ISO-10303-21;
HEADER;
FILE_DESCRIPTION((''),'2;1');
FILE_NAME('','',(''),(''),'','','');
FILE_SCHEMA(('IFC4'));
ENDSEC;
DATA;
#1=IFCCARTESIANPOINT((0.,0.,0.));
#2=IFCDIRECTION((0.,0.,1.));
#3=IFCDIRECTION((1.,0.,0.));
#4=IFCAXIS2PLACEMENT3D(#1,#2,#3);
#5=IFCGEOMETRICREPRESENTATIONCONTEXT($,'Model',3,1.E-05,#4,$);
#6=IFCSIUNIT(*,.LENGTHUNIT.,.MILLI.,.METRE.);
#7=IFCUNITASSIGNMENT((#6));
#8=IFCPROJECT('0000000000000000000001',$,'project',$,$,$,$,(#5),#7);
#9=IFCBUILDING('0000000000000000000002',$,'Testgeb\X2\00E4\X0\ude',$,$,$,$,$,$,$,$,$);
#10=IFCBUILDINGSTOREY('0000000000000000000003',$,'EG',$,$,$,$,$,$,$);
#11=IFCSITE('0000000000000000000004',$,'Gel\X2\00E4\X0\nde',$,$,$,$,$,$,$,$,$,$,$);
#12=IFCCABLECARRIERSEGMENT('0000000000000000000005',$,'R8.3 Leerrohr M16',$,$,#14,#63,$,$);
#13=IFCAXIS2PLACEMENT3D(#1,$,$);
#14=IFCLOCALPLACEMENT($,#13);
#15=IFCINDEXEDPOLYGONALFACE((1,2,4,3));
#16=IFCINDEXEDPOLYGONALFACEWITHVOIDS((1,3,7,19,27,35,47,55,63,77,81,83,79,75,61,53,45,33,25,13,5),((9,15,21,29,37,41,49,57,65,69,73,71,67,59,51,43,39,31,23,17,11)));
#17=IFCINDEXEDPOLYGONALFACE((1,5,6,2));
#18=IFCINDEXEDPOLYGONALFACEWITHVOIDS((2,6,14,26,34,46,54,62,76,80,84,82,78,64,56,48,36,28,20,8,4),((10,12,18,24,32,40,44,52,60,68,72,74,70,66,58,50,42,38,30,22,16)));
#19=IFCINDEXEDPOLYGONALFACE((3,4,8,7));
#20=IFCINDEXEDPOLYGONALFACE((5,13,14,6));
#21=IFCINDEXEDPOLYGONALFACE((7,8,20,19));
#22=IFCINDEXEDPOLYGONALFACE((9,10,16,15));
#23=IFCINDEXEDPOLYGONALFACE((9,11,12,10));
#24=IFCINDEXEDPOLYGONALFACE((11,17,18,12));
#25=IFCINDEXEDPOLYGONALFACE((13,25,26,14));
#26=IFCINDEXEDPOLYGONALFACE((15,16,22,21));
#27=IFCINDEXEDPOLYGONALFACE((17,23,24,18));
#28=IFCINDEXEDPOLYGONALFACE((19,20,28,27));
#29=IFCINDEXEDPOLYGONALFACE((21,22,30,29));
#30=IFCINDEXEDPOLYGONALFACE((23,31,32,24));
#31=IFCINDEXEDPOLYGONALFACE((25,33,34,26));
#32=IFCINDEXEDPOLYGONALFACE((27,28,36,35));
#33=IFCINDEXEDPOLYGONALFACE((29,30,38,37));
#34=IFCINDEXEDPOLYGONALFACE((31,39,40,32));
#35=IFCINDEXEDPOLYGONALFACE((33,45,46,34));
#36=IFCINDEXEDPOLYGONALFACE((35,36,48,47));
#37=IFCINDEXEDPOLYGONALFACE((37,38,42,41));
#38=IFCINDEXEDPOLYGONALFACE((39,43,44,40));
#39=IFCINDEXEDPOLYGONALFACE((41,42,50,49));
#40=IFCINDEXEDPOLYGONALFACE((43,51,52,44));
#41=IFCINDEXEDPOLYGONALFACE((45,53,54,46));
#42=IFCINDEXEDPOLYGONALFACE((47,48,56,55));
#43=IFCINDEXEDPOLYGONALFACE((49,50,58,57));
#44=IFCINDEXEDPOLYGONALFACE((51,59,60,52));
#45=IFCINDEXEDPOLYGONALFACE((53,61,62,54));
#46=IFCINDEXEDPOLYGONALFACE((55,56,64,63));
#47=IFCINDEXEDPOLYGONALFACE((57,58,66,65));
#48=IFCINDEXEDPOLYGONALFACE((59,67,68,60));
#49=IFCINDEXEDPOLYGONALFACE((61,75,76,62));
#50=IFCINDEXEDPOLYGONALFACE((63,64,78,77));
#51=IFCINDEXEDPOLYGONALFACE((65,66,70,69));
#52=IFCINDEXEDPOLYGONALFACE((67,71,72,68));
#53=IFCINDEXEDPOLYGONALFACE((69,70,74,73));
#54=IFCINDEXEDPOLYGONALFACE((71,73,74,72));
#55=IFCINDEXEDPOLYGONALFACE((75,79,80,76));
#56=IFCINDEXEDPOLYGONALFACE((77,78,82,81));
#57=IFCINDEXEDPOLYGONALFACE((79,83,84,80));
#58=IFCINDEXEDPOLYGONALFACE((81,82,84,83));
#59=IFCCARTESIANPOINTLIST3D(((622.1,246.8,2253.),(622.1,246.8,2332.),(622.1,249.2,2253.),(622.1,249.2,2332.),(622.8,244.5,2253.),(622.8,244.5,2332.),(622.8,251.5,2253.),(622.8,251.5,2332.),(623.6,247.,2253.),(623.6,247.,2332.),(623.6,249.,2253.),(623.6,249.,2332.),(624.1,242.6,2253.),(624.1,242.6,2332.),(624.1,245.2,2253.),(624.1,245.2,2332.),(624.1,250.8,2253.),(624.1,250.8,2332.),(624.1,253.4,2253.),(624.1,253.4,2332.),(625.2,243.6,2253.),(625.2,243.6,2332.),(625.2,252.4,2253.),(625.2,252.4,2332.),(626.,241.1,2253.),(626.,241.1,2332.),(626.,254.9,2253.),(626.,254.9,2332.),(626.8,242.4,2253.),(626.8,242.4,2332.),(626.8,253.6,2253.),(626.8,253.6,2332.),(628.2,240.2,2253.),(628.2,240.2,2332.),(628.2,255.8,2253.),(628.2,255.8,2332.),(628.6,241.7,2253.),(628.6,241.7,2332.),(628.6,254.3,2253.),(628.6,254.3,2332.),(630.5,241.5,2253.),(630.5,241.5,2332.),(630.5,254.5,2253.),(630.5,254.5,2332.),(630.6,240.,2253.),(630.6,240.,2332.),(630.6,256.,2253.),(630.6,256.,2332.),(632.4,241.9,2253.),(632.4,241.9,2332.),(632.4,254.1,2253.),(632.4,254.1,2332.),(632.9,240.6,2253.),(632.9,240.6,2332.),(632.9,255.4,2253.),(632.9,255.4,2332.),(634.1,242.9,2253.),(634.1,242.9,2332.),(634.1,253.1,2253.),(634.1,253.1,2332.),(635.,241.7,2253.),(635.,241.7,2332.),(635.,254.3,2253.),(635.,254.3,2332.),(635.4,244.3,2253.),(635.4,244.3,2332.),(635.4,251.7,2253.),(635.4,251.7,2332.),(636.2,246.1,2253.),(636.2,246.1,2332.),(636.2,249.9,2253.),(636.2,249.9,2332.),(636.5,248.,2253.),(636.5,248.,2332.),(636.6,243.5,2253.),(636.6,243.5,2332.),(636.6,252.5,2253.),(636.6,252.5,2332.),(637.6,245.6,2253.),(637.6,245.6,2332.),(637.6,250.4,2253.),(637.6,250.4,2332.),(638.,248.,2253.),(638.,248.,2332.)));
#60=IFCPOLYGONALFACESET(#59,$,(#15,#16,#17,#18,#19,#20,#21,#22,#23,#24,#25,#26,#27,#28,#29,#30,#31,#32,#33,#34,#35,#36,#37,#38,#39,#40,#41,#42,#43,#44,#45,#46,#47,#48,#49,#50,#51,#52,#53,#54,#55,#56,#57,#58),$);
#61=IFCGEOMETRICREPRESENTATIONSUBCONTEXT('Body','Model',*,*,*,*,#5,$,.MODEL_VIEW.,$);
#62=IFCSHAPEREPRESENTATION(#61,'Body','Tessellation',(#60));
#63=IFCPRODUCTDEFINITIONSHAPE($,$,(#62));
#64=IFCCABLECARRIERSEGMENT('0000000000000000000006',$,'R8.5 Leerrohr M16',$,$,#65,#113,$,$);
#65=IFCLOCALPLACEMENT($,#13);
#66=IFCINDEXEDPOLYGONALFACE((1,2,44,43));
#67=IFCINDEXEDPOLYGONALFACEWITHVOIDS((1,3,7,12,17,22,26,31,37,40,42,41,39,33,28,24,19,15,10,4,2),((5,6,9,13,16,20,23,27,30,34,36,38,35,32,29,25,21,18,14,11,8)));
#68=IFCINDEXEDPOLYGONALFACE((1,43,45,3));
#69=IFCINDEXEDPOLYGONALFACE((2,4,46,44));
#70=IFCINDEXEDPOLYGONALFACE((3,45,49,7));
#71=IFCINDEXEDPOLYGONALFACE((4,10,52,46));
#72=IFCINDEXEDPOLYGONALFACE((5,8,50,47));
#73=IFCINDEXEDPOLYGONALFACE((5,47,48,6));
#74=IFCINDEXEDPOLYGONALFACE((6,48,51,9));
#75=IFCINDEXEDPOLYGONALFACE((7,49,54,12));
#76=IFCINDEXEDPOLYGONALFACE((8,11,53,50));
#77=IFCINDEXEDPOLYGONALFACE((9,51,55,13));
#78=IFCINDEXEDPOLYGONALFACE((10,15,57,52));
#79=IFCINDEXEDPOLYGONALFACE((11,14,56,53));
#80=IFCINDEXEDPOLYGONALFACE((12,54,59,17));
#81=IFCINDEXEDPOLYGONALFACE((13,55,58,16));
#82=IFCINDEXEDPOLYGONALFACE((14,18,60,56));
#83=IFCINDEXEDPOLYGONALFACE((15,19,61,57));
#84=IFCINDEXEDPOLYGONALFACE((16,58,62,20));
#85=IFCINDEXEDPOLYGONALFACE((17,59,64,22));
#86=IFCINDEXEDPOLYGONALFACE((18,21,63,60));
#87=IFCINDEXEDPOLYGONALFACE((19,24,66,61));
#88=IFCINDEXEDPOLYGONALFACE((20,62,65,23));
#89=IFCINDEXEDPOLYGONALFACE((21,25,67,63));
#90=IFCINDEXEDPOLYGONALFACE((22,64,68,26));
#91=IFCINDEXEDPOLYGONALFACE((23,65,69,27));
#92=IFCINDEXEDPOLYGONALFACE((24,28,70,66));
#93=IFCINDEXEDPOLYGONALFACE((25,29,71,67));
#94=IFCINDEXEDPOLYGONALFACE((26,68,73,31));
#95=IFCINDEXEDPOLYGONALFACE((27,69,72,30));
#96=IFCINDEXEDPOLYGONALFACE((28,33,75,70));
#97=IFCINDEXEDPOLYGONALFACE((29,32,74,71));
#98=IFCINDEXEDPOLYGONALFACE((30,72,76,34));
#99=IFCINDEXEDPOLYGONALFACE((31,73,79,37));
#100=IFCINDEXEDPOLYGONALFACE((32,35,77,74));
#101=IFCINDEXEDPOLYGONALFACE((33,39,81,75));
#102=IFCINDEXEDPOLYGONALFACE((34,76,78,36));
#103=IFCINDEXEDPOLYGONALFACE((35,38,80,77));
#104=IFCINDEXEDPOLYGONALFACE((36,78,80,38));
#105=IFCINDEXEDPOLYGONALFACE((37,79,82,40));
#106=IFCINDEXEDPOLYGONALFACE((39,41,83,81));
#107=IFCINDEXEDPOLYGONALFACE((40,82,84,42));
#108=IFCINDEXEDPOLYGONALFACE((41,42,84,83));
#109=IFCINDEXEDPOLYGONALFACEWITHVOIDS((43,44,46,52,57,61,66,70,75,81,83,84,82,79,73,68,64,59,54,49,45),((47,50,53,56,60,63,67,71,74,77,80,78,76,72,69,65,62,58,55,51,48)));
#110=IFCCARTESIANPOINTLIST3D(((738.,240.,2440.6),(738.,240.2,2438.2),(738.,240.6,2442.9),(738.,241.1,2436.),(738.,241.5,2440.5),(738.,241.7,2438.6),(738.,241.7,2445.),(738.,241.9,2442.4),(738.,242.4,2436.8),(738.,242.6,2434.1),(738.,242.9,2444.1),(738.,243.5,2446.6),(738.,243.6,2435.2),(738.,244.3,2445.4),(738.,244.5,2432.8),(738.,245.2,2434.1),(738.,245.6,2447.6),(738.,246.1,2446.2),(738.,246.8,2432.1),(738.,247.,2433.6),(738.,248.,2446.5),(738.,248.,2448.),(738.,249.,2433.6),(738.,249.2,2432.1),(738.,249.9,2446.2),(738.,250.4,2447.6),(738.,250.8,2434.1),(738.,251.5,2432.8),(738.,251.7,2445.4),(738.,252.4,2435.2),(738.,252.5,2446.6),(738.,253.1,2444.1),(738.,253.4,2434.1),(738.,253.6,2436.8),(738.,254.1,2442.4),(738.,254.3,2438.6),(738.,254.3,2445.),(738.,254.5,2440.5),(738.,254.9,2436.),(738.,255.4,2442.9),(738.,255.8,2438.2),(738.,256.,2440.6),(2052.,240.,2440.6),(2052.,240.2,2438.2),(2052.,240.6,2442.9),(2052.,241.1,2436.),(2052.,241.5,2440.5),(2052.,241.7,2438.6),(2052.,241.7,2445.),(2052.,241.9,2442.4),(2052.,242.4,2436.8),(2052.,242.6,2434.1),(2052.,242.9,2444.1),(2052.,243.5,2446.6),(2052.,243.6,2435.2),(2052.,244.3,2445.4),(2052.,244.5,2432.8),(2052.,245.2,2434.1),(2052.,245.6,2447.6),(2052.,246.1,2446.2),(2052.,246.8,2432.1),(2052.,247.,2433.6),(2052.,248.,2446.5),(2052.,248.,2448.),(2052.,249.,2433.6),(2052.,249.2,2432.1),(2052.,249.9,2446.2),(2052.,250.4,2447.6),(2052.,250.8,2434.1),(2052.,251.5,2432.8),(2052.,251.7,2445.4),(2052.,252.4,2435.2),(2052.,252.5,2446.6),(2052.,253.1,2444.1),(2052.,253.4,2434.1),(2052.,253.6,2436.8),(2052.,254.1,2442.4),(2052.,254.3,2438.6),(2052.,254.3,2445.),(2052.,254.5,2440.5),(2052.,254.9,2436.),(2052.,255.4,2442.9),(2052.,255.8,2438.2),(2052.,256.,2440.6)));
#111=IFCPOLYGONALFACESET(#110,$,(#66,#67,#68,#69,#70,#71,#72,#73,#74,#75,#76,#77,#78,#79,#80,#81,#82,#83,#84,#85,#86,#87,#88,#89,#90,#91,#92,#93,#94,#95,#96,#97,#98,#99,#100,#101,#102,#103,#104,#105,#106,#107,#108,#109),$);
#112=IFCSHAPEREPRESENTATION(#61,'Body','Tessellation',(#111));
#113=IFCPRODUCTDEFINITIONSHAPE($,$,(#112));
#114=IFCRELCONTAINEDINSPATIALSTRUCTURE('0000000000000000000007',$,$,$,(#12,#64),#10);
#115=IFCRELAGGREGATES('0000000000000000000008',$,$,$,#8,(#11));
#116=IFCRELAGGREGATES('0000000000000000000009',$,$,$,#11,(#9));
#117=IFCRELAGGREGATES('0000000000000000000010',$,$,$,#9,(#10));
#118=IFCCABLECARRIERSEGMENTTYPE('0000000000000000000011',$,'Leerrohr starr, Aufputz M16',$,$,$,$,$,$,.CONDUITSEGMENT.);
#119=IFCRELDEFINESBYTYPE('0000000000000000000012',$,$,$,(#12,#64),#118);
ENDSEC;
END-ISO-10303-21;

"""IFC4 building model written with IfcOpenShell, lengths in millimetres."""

from ifc_helpers import new_model, si_unit, frame, origin_with_axes, place, context, subcontext, project, spatial, hollow_circle, extrude, type_object, element, save


model = new_model("IFC4")

# Units and contexts
model_context = context("Model", 3, precision=1e-05, world=origin_with_axes())
body_context = subcontext(model_context, "Body", "Model", "MODEL_VIEW")
ifc_project = project(units=[si_unit("LENGTHUNIT", "METRE", prefix="MILLI")], contexts=[model_context])

# Site, building, storey
site = spatial("IfcSite", under=ifc_project, Name="Gelände")
building = spatial("IfcBuilding", under=site, Name="Testgebäude")
storey = spatial("IfcBuildingStorey", under=building, Name="EG")

# Cable carrier segments
cable_carrier_segment_type_1 = type_object("IfcCableCarrierSegmentType", Name="Leerrohr starr, Aufputz M16", PredefinedType="CONDUITSEGMENT")
cable_carrier_segment_1_placement = place(None, frame((630.0, 248.0, 2253.0), z_axis=(0.0, 0.0, 1.0), x_axis=(1.0, 0.0, 0.0)))
element("IfcCableCarrierSegment", 1, at=cable_carrier_segment_1_placement, inside=storey, type_object=cable_carrier_segment_type_1, Name="R8.3 Leerrohr M16", context=body_context, shape_type="SweptSolid", body=[
    extrude(hollow_circle(Radius=8.0, WallThickness=1.5), None, (0.0, 0.0, 1.0), 79.0),
])
cable_carrier_segment_2_placement = place(None, frame((738.0, 248.0, 2440.0), z_axis=(1.0, 0.0, 0.0), x_axis=(0.0, 0.0, 1.0)))
element("IfcCableCarrierSegment", 2, at=cable_carrier_segment_2_placement, inside=storey, type_object=cable_carrier_segment_type_1, Name="R8.5 Leerrohr M16", context=body_context, shape_type="SweptSolid", body=[
    extrude(hollow_circle(Radius=8.0, WallThickness=1.5), None, (0.0, 0.0, 1.0), 1314.0),
])

save(model, "model.ifc")
